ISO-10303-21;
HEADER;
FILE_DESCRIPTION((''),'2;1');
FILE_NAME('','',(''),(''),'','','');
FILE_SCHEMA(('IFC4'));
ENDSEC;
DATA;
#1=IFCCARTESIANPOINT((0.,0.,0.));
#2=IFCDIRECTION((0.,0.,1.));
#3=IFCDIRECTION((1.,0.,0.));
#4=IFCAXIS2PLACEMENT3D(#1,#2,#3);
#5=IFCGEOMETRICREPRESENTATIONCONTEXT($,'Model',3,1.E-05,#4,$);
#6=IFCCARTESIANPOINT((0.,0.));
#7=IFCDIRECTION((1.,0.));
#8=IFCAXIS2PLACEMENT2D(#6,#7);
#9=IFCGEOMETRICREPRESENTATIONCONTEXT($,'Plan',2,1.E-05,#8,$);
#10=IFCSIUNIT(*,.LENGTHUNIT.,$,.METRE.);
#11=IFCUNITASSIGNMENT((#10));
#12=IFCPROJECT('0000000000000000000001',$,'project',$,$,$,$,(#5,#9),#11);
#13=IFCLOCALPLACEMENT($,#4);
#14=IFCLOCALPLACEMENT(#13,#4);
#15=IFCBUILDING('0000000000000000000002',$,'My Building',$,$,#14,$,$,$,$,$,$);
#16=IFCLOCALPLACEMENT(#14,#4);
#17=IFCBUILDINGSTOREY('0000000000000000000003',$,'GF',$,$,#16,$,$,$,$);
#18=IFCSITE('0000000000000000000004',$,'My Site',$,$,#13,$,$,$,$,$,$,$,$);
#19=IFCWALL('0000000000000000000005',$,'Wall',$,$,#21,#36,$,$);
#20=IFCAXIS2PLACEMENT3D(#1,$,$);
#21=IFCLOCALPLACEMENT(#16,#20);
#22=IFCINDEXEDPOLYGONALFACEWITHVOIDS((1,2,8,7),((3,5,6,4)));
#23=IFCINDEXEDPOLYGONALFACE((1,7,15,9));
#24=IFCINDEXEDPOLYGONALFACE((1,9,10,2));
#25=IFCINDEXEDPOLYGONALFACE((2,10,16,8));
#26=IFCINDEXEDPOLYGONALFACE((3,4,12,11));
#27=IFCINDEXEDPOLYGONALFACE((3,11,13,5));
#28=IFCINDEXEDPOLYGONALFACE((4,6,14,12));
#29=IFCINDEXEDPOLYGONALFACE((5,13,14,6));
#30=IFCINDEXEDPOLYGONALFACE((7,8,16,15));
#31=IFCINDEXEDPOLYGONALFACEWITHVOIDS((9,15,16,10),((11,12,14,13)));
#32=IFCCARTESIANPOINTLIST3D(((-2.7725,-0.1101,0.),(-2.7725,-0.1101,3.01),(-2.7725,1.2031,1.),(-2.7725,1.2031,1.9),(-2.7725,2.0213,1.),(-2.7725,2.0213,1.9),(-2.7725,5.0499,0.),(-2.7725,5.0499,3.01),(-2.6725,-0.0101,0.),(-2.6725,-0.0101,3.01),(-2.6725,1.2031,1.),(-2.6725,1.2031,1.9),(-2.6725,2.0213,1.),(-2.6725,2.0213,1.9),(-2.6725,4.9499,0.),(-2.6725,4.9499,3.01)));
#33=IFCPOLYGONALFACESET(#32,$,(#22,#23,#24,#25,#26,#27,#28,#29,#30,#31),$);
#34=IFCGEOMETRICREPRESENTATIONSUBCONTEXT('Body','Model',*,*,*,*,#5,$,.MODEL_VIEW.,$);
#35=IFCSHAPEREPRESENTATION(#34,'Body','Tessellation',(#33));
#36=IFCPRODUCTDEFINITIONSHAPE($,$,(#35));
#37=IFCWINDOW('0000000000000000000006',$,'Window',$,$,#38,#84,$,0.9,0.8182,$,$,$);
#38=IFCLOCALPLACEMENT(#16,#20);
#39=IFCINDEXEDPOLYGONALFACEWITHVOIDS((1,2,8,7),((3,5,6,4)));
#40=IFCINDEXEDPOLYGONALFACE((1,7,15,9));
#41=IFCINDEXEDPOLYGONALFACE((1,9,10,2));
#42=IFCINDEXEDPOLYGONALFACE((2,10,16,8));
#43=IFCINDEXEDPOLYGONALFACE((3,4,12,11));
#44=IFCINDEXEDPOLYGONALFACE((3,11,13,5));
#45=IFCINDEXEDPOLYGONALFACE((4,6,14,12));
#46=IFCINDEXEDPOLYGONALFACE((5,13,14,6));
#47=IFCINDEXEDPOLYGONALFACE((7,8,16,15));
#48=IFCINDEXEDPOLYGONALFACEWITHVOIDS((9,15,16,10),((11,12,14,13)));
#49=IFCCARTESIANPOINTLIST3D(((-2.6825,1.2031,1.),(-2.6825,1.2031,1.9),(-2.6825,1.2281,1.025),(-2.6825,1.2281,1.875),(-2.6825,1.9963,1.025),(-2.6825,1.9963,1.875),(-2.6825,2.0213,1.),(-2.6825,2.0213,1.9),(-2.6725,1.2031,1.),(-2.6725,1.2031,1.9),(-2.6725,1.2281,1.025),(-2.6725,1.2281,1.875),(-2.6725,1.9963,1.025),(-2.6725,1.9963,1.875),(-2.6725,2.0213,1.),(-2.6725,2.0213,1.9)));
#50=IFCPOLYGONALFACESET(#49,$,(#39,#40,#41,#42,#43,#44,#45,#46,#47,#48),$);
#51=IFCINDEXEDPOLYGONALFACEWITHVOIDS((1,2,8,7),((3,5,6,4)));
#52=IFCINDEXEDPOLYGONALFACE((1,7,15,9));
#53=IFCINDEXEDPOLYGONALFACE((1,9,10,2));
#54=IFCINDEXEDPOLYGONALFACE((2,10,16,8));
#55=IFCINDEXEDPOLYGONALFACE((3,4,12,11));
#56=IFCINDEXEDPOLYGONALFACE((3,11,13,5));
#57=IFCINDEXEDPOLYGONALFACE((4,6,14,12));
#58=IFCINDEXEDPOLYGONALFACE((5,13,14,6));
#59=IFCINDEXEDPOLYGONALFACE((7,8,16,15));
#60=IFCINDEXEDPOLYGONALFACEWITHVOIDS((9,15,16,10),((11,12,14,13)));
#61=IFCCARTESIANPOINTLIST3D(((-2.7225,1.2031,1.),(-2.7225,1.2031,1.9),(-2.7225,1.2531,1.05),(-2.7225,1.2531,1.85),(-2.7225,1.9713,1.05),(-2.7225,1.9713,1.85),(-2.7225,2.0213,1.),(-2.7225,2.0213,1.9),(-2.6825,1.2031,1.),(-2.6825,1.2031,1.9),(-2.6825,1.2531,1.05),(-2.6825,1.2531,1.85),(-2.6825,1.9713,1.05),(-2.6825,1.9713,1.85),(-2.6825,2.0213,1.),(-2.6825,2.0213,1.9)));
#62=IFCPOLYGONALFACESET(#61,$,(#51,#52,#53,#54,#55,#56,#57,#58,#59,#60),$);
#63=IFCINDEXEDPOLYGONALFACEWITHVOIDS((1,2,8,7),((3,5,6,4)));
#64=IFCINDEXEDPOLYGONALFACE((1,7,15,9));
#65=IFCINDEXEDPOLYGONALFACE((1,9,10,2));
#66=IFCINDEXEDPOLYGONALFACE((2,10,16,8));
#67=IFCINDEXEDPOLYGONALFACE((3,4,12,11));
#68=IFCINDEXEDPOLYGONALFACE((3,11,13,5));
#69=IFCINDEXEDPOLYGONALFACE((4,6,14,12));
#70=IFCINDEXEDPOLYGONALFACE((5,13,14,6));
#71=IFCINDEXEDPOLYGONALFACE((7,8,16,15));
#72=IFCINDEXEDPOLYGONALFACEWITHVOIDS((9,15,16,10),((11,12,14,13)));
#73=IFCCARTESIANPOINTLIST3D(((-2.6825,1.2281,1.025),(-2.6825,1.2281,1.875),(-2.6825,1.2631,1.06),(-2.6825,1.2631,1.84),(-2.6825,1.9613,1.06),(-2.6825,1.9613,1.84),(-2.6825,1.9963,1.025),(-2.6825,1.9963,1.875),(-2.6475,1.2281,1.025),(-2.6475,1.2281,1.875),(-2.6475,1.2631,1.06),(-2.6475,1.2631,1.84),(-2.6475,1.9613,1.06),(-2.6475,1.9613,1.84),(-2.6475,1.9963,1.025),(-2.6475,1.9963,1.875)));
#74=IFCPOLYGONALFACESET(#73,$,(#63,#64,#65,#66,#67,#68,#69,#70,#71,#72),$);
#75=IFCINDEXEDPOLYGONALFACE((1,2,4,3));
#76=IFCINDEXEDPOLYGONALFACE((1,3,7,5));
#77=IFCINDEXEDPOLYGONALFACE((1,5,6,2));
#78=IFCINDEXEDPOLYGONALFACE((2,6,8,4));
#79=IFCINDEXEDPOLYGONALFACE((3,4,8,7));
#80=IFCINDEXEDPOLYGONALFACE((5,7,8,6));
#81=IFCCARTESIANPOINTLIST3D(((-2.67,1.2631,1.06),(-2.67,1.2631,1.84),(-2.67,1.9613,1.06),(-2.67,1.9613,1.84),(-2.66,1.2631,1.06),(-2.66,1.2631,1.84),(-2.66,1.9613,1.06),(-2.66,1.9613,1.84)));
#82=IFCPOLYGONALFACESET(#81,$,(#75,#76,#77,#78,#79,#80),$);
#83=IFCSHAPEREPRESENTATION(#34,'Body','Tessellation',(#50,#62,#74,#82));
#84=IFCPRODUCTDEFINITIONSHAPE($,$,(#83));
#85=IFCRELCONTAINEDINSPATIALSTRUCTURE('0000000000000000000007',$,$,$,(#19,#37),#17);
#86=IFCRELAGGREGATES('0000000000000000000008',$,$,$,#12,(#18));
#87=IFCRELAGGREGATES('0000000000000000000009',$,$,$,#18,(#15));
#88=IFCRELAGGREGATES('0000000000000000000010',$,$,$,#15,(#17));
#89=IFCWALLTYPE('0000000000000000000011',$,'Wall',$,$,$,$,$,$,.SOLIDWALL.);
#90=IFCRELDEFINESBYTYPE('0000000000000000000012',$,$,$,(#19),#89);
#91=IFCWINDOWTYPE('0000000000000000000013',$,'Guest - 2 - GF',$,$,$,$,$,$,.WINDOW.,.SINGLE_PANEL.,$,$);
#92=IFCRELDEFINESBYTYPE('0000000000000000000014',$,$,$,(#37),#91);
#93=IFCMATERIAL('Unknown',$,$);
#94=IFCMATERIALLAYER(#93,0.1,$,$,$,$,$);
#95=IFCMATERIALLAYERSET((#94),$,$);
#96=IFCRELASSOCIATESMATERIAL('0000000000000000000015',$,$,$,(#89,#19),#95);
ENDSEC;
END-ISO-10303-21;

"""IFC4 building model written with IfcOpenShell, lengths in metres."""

from ifc_helpers import new_model, entity, si_unit, frame, origin_with_axes, origin_2d_with_axis, place, context, subcontext, project, spatial, line, indexed_curve, outline, extrude, shape, source, transform, mapped, material, layer, layer_set, layer_usage, type_object, type_shapes, element, fill, save


model = new_model("IFC4")

# Units and contexts
model_context = context("Model", 3, precision=1e-05, world=origin_with_axes())
plan_context = context("Plan", 2, precision=1e-05, world=origin_2d_with_axis())
body_context_1 = subcontext(model_context, "Body", "Model", "MODEL_VIEW")
body_context_2 = subcontext(plan_context, "Body", "Plan", "PLAN_VIEW")
ifc_project = project(units=[si_unit("LENGTHUNIT", "METRE")], contexts=[model_context, plan_context])

# Site, building, storey
site_placement = place(None, origin_with_axes())
site = spatial("IfcSite", under=ifc_project, at=site_placement, Name="My Site")
building_placement = place(site_placement, origin_with_axes())
building = spatial("IfcBuilding", under=site, at=building_placement, Name="My Building")
storey_placement = place(building_placement, origin_with_axes())
storey = spatial("IfcBuildingStorey", under=building, at=storey_placement, Name="GF")

# Shared definitions
ifc_material = material(Name="Unknown")

# Shared definitions
ifc_layer_1 = layer(ifc_material, 0.1)
ifc_layer_set_1 = layer_set([ifc_layer_1])
wall_type = type_object("IfcWallType", Name="Wall", PredefinedType="SOLIDWALL", material=ifc_layer_set_1)

# Wall, opening, window
ifc_layer_usage_1 = layer_usage(ifc_layer_set_1, "AXIS2", "POSITIVE", 0.0)
wall_1_placement = place(storey_placement, frame((-2.7725, 5.0499, 0.0), z_axis=(0.0, 0.0, 1.0), x_axis=(0.0, -1.0, 0.0)))
wall_1 = element("IfcWall", 1, at=wall_1_placement, inside=storey, type_object=wall_type, material=ifc_layer_usage_1, Name="Wall", context=body_context_1, shape_type="SweptSolid", body=[
    extrude(outline(indexed_curve([(0.0, 0.0), (0.1, 0.1), (5.06, 0.1), (5.16, 0.0)], segments=[line(1, 2, 3, 4, 1)])), origin_with_axes(), (0.0, 0.0, 1.0), 3.01),
])
shared_shape_1 = source(origin_with_axes(), body_context_1, "Body", "SweptSolid", [
    extrude(outline(indexed_curve([(0.0, 0.0), (0.8182, 0.0), (0.8182, 0.9), (0.0, 0.9)], segments=[line(1, 2, 3, 4, 1)])), frame((0.0, -0.6, 0.0), z_axis=(0.0, -1.0, 0.0), x_axis=(1.0, 0.0, 0.0)), (0.0, 0.0, -1.0), 1.2),
])
opening_1_placement = place(wall_1_placement, frame((3.0286, 0.0, 1.0), z_axis=(0.0, 0.0, 1.0), x_axis=(1.0, 0.0, 0.0)))
opening_1 = element("IfcOpeningElement", 2, at=opening_1_placement, cuts=wall_1, PredefinedType="OPENING", context=body_context_1, shape_type="MappedRepresentation", body=[
    mapped(shared_shape_1, transform((0.0, 0.0, 0.0), x_axis=(1.0, 0.0, 0.0), y_axis=(0.0, 1.0, 0.0), z_axis=(0.0, 0.0, 1.0), scale=1.0)),
])
window_type_1 = type_object("IfcWindowType", Name="Guest - 2 - GF", PartitioningType="SINGLE_PANEL", PredefinedType="WINDOW")
shared_shape_2 = source(origin_with_axes(), body_context_1, "Body", "SweptSolid", [
    extrude(outline(indexed_curve([(0.0, 0.0), (0.8182, 0.0), (0.8182, 0.9), (0.0, 0.9)], segments=[line(1, 2, 3, 4, 1)]), holes=[indexed_curve([(0.025, 0.025), (0.7932, 0.025), (0.7932, 0.875), (0.025, 0.875)], segments=[line(1, 2, 3, 4, 1)])]), frame((0.0, 0.09, 0.0), z_axis=(0.0, -1.0, 0.0), x_axis=(1.0, 0.0, 0.0)), (0.0, 0.0, -1.0), 0.01),
    extrude(outline(indexed_curve([(0.0, 0.0), (0.8182, 0.0), (0.8182, 0.9), (0.0, 0.9)], segments=[line(1, 2, 3, 4, 1)]), holes=[indexed_curve([(0.05, 0.05), (0.7682, 0.05), (0.7682, 0.85), (0.05, 0.85)], segments=[line(1, 2, 3, 4, 1)])]), frame((0.0, 0.05, 0.0), z_axis=(0.0, -1.0, 0.0), x_axis=(1.0, 0.0, 0.0)), (0.0, 0.0, -1.0), 0.04),
    extrude(outline(indexed_curve([(0.0, 0.0), (0.7682, 0.0), (0.7682, 0.85), (0.0, 0.85)], segments=[line(1, 2, 3, 4, 1)]), holes=[indexed_curve([(0.035, 0.035), (0.7332, 0.035), (0.7332, 0.815), (0.035, 0.815)], segments=[line(1, 2, 3, 4, 1)])]), frame((0.025, 0.09, 0.025), z_axis=(0.0, -1.0, 0.0), x_axis=(1.0, 0.0, 0.0)), (0.0, 0.0, -1.0), 0.035),
    extrude(outline(indexed_curve([(0.035, 0.035), (0.7332, 0.035), (0.7332, 0.815), (0.035, 0.815)], segments=[line(1, 2, 3, 4, 1)])), frame((0.025, 0.1025, 0.025), z_axis=(0.0, -1.0, 0.0), x_axis=(1.0, 0.0, 0.0)), (0.0, 0.0, -1.0), 0.01),
])
shared_shape_3 = source(origin_with_axes(), body_context_2, "Body", "Curve2D", [
    entity("IfcIndexedPolyCurve", entity("IfcCartesianPointList2D", [[0.05, 0.05], [0.7682, 0.05]])),
    entity("IfcIndexedPolyCurve", entity("IfcCartesianPointList2D", [[0.0, 0.1], [0.025, 0.1], [0.025, 0.09], [0.05, 0.09], [0.05, 0.05], [0.0, 0.05]]), [entity("IfcLineIndex", [1, 2, 3, 4, 5, 6, 1])]),
    entity("IfcIndexedPolyCurve", entity("IfcCartesianPointList2D", [[0.8182, 0.1], [0.7932, 0.1], [0.7932, 0.09], [0.7682, 0.09], [0.7682, 0.05], [0.8182, 0.05]]), [entity("IfcLineIndex", [1, 2, 3, 4, 5, 6, 1])]),
    entity("IfcIndexedPolyCurve", entity("IfcCartesianPointList2D", [[0.025, 0.09], [0.06, 0.09], [0.06, 0.125], [0.025, 0.125]]), [entity("IfcLineIndex", [1, 2, 3, 4, 1])]),
    entity("IfcIndexedPolyCurve", entity("IfcCartesianPointList2D", [[0.7932, 0.09], [0.7582, 0.09], [0.7582, 0.125], [0.7932, 0.125]]), [entity("IfcLineIndex", [1, 2, 3, 4, 1])]),
    entity("IfcIndexedPolyCurve", entity("IfcCartesianPointList2D", [[0.06, 0.09], [0.7582, 0.09]])),
    entity("IfcIndexedPolyCurve", entity("IfcCartesianPointList2D", [[0.06, 0.125], [0.7582, 0.125]])),
    entity("IfcIndexedPolyCurve", entity("IfcCartesianPointList2D", [[0.06, 0.1075], [0.7582, 0.1075]])),
])
type_shapes(window_type_1, [shared_shape_2, shared_shape_3])
window_1_placement = place(opening_1_placement, frame((0.0, 0.0, 0.0), z_axis=(0.0, 0.0, 1.0), x_axis=(1.0, 0.0, 0.0)))
window_1 = element("IfcWindow", 3, at=window_1_placement, inside=storey, type_object=window_type_1, Name="Window", OverallHeight=0.9, OverallWidth=0.8182, shapes=[
    shape(body_context_1, "Body", "MappedRepresentation", [mapped(shared_shape_2, transform((0.0, 0.0, 0.0), x_axis=(1.0, 0.0, 0.0), y_axis=(0.0, 1.0, 0.0), z_axis=(0.0, 0.0, 1.0), scale=1.0))]),
    shape(body_context_2, "Body", "MappedRepresentation", [mapped(shared_shape_3, transform((0.0, 0.0, 0.0), x_axis=(1.0, 0.0, 0.0), y_axis=(0.0, 1.0, 0.0), z_axis=(0.0, 0.0, 1.0), scale=1.0))]),
])
fill(opening_1, window_1)

save(model, "model.ifc")
